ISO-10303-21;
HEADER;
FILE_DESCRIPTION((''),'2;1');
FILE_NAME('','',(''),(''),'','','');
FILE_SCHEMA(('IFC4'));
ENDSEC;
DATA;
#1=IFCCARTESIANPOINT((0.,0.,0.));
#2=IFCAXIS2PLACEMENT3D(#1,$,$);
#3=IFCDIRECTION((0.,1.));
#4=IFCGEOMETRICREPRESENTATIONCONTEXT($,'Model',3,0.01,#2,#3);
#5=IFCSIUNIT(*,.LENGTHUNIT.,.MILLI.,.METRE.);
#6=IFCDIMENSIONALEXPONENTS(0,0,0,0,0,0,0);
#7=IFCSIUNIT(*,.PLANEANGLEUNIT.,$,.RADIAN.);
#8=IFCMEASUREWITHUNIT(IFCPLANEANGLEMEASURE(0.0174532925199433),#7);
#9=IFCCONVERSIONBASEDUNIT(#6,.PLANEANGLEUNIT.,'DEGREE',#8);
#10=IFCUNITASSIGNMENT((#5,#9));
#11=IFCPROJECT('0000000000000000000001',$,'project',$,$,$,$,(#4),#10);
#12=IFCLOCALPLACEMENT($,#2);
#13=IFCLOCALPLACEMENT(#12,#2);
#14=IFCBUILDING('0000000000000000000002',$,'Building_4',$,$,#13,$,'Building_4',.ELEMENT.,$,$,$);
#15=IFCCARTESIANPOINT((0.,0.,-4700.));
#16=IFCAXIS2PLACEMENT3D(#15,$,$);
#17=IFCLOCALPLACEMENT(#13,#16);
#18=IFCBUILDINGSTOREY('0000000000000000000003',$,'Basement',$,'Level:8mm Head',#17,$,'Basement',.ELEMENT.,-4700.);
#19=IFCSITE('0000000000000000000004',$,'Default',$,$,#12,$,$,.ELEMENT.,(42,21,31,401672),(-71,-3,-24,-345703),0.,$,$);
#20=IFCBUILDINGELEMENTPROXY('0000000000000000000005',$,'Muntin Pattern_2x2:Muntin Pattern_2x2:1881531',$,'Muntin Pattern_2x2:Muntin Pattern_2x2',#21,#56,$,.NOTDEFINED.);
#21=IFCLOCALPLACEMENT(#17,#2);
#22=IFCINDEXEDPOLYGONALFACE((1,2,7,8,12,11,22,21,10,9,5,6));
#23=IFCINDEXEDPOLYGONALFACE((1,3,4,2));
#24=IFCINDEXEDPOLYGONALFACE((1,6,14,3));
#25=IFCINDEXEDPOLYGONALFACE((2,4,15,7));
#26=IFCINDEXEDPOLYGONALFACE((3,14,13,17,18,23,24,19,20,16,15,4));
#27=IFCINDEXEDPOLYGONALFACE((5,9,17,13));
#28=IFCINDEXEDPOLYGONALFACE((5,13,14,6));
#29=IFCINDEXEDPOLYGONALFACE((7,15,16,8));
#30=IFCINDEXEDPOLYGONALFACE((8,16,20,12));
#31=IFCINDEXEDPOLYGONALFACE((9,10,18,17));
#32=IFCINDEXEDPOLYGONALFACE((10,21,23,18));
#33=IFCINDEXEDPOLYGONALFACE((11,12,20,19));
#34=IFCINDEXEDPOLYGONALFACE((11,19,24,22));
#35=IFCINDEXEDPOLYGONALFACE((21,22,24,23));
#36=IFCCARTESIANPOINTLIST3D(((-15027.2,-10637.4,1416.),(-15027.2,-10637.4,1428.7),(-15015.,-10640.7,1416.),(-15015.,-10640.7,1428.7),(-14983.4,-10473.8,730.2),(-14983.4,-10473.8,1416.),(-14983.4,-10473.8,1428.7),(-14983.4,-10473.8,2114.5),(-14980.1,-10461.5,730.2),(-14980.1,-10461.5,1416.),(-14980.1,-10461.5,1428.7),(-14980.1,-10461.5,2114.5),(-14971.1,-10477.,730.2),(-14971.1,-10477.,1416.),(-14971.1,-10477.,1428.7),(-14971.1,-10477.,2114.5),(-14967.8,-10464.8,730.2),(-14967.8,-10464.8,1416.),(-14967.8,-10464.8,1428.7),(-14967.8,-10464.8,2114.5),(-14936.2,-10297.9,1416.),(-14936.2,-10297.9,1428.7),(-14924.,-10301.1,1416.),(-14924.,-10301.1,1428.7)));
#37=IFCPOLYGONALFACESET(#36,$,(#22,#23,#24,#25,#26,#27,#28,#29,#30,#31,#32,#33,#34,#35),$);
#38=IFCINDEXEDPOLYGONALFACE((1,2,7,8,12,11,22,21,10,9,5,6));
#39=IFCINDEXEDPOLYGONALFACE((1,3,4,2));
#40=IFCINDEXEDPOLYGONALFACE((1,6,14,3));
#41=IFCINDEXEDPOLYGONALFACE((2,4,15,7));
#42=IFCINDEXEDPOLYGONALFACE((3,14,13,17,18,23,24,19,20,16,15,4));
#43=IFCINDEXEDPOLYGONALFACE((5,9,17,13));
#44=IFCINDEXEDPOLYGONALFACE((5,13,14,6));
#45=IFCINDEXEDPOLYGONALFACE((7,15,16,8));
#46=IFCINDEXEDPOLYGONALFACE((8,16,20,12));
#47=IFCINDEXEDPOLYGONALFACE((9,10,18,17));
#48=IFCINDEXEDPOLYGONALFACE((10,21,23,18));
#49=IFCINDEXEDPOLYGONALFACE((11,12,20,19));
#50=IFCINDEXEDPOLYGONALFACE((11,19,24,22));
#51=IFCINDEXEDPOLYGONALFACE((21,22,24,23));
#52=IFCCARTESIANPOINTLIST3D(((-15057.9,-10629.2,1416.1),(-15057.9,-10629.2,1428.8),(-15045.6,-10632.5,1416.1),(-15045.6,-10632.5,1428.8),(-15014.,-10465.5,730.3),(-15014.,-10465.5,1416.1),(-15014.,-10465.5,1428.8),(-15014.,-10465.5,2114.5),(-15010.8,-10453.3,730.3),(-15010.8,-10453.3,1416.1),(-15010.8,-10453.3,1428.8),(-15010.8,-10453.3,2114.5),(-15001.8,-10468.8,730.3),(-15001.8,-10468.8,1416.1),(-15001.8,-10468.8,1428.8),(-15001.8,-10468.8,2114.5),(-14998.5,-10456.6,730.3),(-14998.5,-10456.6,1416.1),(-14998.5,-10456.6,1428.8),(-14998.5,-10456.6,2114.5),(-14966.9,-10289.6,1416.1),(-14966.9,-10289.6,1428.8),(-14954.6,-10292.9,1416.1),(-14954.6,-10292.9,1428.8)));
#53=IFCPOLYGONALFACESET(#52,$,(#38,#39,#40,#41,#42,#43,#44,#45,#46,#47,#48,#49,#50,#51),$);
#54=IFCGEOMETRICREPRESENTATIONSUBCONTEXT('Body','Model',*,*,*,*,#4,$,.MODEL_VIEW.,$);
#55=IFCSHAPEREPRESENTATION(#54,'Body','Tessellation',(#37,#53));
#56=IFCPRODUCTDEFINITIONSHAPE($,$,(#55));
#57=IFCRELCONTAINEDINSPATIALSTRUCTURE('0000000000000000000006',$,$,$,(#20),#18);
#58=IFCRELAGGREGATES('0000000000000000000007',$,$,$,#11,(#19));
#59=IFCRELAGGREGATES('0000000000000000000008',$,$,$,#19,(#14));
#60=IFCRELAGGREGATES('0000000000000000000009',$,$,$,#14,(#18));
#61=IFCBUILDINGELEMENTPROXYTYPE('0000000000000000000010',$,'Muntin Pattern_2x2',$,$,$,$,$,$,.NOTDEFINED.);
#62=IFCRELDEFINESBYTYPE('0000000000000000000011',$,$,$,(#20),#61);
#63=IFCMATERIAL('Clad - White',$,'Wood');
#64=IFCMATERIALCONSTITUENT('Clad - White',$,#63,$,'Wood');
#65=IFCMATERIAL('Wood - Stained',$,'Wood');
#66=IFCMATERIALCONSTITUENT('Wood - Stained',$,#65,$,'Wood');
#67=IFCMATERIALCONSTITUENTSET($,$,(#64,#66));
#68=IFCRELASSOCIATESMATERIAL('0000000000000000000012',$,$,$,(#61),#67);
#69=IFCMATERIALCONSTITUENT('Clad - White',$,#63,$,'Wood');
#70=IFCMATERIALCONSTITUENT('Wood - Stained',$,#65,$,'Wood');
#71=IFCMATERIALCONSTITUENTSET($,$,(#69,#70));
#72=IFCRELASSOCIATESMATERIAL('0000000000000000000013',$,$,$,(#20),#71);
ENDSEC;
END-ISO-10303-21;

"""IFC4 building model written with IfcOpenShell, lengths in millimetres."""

from ifc_helpers import new_model, entity, si_unit, converted_unit, direction, frame, origin, place, context, subcontext, project, spatial, indexed_curve, outline, extrude, source, transform, mapped, material, constituent, constituent_set, type_object, type_shapes, element, save


model = new_model("IFC4")

# Units and contexts
model_context = context("Model", 3, precision=0.01, world=origin(), true_north=direction((0.0, 1.0)))
body_context = subcontext(model_context, "Body", "Model", "MODEL_VIEW")
ifc_project = project(units=[si_unit("LENGTHUNIT", "METRE", prefix="MILLI"), converted_unit("PLANEANGLEUNIT", "DEGREE", entity("IfcPlaneAngleMeasure", 0.0174532925199433), si_unit("PLANEANGLEUNIT", "RADIAN"), dimensions=[0, 0, 0, 0, 0, 0, 0])], contexts=[model_context])

# Site, building, storey
site_placement = place(None, origin())
site = spatial("IfcSite", under=ifc_project, at=site_placement, Name="Default", CompositionType="ELEMENT", RefLatitude=(42, 21, 31, 401672), RefLongitude=(-71, -3, -24, -345703), RefElevation=0.0)
building_placement = place(site_placement, origin())
building = spatial("IfcBuilding", under=site, at=building_placement, Name="Building_4", LongName="Building_4", CompositionType="ELEMENT")
storey_placement = place(building_placement, frame((0.0, 0.0, -4700.0)))
storey = spatial("IfcBuildingStorey", under=building, at=storey_placement, Name="Basement", ObjectType="Level:8mm Head", LongName="Basement", CompositionType="ELEMENT", Elevation=-4700.0)

# Building element proxy
ifc_material_1 = material(Name="Clad - White", Category="Wood")
ifc_material_2 = material(Name="Wood - Stained", Category="Wood")
ifc_constituent_1 = constituent(ifc_material_1, Name="Clad - White", Category="Wood")
ifc_constituent_2 = constituent(ifc_material_2, Name="Wood - Stained", Category="Wood")
ifc_constituent_set_1 = constituent_set(constituents=[ifc_constituent_1, ifc_constituent_2])
building_element_proxy_type = type_object("IfcBuildingElementProxyType", Name="Muntin Pattern_2x2", PredefinedType="NOTDEFINED", material=ifc_constituent_set_1)
shared_shape_1 = source(origin(), body_context, "Body", "SweptSolid", [
    extrude(outline(indexed_curve([(6.4, -6.4), (692.1, -6.4), (692.1, 6.3), (6.4, 6.3), (6.4, 175.8), (-6.3, 175.8), (-6.3, 6.3), (-692.2, 6.3), (-692.2, -6.4), (-6.3, -6.4), (-6.3, -175.8), (6.4, -175.8), (6.4, -6.4)], self_intersect=False)), frame((0.0, -22.2, 692.1), z_axis=(0.0, 1.0, 0.0), x_axis=(0.0, 0.0, 1.0)), (0.0, 0.0, 1.0), 12.7),
    extrude(outline(indexed_curve([(6.4, -6.4), (692.1, -6.4), (692.1, 6.3), (6.4, 6.3), (6.4, 175.8), (-6.3, 175.8), (-6.3, 6.3), (-692.1, 6.3), (-692.1, -6.4), (-6.3, -6.4), (-6.3, -175.8), (6.4, -175.8), (6.4, -6.4)], self_intersect=False)), frame((0.0, 9.5, 692.1), z_axis=(0.0, 1.0, 0.0), x_axis=(0.0, 0.0, 1.0)), (0.0, 0.0, 1.0), 12.7),
])
type_shapes(building_element_proxy_type, [shared_shape_1])
ifc_constituent_3 = constituent(ifc_material_1, Name="Clad - White", Category="Wood")
ifc_constituent_4 = constituent(ifc_material_2, Name="Wood - Stained", Category="Wood")
ifc_constituent_set_2 = constituent_set(constituents=[ifc_constituent_3, ifc_constituent_4])
proxy_1_placement = place(storey_placement, frame((-14990.9, -10465.2, 730.3), z_axis=(0.0, 0.0, 1.0), x_axis=(0.258819, 0.965926, 0.0)))
element("IfcBuildingElementProxy", 1, at=proxy_1_placement, inside=storey, type_object=building_element_proxy_type, material=ifc_constituent_set_2, Name="Muntin Pattern_2x2:Muntin Pattern_2x2:1881531", ObjectType="Muntin Pattern_2x2:Muntin Pattern_2x2", PredefinedType="NOTDEFINED", context=body_context, shape_type="MappedRepresentation", body=[
    mapped(shared_shape_1, transform((0.0, 0.0, 0.0), scale=1.0)),
])

save(model, "model.ifc")
